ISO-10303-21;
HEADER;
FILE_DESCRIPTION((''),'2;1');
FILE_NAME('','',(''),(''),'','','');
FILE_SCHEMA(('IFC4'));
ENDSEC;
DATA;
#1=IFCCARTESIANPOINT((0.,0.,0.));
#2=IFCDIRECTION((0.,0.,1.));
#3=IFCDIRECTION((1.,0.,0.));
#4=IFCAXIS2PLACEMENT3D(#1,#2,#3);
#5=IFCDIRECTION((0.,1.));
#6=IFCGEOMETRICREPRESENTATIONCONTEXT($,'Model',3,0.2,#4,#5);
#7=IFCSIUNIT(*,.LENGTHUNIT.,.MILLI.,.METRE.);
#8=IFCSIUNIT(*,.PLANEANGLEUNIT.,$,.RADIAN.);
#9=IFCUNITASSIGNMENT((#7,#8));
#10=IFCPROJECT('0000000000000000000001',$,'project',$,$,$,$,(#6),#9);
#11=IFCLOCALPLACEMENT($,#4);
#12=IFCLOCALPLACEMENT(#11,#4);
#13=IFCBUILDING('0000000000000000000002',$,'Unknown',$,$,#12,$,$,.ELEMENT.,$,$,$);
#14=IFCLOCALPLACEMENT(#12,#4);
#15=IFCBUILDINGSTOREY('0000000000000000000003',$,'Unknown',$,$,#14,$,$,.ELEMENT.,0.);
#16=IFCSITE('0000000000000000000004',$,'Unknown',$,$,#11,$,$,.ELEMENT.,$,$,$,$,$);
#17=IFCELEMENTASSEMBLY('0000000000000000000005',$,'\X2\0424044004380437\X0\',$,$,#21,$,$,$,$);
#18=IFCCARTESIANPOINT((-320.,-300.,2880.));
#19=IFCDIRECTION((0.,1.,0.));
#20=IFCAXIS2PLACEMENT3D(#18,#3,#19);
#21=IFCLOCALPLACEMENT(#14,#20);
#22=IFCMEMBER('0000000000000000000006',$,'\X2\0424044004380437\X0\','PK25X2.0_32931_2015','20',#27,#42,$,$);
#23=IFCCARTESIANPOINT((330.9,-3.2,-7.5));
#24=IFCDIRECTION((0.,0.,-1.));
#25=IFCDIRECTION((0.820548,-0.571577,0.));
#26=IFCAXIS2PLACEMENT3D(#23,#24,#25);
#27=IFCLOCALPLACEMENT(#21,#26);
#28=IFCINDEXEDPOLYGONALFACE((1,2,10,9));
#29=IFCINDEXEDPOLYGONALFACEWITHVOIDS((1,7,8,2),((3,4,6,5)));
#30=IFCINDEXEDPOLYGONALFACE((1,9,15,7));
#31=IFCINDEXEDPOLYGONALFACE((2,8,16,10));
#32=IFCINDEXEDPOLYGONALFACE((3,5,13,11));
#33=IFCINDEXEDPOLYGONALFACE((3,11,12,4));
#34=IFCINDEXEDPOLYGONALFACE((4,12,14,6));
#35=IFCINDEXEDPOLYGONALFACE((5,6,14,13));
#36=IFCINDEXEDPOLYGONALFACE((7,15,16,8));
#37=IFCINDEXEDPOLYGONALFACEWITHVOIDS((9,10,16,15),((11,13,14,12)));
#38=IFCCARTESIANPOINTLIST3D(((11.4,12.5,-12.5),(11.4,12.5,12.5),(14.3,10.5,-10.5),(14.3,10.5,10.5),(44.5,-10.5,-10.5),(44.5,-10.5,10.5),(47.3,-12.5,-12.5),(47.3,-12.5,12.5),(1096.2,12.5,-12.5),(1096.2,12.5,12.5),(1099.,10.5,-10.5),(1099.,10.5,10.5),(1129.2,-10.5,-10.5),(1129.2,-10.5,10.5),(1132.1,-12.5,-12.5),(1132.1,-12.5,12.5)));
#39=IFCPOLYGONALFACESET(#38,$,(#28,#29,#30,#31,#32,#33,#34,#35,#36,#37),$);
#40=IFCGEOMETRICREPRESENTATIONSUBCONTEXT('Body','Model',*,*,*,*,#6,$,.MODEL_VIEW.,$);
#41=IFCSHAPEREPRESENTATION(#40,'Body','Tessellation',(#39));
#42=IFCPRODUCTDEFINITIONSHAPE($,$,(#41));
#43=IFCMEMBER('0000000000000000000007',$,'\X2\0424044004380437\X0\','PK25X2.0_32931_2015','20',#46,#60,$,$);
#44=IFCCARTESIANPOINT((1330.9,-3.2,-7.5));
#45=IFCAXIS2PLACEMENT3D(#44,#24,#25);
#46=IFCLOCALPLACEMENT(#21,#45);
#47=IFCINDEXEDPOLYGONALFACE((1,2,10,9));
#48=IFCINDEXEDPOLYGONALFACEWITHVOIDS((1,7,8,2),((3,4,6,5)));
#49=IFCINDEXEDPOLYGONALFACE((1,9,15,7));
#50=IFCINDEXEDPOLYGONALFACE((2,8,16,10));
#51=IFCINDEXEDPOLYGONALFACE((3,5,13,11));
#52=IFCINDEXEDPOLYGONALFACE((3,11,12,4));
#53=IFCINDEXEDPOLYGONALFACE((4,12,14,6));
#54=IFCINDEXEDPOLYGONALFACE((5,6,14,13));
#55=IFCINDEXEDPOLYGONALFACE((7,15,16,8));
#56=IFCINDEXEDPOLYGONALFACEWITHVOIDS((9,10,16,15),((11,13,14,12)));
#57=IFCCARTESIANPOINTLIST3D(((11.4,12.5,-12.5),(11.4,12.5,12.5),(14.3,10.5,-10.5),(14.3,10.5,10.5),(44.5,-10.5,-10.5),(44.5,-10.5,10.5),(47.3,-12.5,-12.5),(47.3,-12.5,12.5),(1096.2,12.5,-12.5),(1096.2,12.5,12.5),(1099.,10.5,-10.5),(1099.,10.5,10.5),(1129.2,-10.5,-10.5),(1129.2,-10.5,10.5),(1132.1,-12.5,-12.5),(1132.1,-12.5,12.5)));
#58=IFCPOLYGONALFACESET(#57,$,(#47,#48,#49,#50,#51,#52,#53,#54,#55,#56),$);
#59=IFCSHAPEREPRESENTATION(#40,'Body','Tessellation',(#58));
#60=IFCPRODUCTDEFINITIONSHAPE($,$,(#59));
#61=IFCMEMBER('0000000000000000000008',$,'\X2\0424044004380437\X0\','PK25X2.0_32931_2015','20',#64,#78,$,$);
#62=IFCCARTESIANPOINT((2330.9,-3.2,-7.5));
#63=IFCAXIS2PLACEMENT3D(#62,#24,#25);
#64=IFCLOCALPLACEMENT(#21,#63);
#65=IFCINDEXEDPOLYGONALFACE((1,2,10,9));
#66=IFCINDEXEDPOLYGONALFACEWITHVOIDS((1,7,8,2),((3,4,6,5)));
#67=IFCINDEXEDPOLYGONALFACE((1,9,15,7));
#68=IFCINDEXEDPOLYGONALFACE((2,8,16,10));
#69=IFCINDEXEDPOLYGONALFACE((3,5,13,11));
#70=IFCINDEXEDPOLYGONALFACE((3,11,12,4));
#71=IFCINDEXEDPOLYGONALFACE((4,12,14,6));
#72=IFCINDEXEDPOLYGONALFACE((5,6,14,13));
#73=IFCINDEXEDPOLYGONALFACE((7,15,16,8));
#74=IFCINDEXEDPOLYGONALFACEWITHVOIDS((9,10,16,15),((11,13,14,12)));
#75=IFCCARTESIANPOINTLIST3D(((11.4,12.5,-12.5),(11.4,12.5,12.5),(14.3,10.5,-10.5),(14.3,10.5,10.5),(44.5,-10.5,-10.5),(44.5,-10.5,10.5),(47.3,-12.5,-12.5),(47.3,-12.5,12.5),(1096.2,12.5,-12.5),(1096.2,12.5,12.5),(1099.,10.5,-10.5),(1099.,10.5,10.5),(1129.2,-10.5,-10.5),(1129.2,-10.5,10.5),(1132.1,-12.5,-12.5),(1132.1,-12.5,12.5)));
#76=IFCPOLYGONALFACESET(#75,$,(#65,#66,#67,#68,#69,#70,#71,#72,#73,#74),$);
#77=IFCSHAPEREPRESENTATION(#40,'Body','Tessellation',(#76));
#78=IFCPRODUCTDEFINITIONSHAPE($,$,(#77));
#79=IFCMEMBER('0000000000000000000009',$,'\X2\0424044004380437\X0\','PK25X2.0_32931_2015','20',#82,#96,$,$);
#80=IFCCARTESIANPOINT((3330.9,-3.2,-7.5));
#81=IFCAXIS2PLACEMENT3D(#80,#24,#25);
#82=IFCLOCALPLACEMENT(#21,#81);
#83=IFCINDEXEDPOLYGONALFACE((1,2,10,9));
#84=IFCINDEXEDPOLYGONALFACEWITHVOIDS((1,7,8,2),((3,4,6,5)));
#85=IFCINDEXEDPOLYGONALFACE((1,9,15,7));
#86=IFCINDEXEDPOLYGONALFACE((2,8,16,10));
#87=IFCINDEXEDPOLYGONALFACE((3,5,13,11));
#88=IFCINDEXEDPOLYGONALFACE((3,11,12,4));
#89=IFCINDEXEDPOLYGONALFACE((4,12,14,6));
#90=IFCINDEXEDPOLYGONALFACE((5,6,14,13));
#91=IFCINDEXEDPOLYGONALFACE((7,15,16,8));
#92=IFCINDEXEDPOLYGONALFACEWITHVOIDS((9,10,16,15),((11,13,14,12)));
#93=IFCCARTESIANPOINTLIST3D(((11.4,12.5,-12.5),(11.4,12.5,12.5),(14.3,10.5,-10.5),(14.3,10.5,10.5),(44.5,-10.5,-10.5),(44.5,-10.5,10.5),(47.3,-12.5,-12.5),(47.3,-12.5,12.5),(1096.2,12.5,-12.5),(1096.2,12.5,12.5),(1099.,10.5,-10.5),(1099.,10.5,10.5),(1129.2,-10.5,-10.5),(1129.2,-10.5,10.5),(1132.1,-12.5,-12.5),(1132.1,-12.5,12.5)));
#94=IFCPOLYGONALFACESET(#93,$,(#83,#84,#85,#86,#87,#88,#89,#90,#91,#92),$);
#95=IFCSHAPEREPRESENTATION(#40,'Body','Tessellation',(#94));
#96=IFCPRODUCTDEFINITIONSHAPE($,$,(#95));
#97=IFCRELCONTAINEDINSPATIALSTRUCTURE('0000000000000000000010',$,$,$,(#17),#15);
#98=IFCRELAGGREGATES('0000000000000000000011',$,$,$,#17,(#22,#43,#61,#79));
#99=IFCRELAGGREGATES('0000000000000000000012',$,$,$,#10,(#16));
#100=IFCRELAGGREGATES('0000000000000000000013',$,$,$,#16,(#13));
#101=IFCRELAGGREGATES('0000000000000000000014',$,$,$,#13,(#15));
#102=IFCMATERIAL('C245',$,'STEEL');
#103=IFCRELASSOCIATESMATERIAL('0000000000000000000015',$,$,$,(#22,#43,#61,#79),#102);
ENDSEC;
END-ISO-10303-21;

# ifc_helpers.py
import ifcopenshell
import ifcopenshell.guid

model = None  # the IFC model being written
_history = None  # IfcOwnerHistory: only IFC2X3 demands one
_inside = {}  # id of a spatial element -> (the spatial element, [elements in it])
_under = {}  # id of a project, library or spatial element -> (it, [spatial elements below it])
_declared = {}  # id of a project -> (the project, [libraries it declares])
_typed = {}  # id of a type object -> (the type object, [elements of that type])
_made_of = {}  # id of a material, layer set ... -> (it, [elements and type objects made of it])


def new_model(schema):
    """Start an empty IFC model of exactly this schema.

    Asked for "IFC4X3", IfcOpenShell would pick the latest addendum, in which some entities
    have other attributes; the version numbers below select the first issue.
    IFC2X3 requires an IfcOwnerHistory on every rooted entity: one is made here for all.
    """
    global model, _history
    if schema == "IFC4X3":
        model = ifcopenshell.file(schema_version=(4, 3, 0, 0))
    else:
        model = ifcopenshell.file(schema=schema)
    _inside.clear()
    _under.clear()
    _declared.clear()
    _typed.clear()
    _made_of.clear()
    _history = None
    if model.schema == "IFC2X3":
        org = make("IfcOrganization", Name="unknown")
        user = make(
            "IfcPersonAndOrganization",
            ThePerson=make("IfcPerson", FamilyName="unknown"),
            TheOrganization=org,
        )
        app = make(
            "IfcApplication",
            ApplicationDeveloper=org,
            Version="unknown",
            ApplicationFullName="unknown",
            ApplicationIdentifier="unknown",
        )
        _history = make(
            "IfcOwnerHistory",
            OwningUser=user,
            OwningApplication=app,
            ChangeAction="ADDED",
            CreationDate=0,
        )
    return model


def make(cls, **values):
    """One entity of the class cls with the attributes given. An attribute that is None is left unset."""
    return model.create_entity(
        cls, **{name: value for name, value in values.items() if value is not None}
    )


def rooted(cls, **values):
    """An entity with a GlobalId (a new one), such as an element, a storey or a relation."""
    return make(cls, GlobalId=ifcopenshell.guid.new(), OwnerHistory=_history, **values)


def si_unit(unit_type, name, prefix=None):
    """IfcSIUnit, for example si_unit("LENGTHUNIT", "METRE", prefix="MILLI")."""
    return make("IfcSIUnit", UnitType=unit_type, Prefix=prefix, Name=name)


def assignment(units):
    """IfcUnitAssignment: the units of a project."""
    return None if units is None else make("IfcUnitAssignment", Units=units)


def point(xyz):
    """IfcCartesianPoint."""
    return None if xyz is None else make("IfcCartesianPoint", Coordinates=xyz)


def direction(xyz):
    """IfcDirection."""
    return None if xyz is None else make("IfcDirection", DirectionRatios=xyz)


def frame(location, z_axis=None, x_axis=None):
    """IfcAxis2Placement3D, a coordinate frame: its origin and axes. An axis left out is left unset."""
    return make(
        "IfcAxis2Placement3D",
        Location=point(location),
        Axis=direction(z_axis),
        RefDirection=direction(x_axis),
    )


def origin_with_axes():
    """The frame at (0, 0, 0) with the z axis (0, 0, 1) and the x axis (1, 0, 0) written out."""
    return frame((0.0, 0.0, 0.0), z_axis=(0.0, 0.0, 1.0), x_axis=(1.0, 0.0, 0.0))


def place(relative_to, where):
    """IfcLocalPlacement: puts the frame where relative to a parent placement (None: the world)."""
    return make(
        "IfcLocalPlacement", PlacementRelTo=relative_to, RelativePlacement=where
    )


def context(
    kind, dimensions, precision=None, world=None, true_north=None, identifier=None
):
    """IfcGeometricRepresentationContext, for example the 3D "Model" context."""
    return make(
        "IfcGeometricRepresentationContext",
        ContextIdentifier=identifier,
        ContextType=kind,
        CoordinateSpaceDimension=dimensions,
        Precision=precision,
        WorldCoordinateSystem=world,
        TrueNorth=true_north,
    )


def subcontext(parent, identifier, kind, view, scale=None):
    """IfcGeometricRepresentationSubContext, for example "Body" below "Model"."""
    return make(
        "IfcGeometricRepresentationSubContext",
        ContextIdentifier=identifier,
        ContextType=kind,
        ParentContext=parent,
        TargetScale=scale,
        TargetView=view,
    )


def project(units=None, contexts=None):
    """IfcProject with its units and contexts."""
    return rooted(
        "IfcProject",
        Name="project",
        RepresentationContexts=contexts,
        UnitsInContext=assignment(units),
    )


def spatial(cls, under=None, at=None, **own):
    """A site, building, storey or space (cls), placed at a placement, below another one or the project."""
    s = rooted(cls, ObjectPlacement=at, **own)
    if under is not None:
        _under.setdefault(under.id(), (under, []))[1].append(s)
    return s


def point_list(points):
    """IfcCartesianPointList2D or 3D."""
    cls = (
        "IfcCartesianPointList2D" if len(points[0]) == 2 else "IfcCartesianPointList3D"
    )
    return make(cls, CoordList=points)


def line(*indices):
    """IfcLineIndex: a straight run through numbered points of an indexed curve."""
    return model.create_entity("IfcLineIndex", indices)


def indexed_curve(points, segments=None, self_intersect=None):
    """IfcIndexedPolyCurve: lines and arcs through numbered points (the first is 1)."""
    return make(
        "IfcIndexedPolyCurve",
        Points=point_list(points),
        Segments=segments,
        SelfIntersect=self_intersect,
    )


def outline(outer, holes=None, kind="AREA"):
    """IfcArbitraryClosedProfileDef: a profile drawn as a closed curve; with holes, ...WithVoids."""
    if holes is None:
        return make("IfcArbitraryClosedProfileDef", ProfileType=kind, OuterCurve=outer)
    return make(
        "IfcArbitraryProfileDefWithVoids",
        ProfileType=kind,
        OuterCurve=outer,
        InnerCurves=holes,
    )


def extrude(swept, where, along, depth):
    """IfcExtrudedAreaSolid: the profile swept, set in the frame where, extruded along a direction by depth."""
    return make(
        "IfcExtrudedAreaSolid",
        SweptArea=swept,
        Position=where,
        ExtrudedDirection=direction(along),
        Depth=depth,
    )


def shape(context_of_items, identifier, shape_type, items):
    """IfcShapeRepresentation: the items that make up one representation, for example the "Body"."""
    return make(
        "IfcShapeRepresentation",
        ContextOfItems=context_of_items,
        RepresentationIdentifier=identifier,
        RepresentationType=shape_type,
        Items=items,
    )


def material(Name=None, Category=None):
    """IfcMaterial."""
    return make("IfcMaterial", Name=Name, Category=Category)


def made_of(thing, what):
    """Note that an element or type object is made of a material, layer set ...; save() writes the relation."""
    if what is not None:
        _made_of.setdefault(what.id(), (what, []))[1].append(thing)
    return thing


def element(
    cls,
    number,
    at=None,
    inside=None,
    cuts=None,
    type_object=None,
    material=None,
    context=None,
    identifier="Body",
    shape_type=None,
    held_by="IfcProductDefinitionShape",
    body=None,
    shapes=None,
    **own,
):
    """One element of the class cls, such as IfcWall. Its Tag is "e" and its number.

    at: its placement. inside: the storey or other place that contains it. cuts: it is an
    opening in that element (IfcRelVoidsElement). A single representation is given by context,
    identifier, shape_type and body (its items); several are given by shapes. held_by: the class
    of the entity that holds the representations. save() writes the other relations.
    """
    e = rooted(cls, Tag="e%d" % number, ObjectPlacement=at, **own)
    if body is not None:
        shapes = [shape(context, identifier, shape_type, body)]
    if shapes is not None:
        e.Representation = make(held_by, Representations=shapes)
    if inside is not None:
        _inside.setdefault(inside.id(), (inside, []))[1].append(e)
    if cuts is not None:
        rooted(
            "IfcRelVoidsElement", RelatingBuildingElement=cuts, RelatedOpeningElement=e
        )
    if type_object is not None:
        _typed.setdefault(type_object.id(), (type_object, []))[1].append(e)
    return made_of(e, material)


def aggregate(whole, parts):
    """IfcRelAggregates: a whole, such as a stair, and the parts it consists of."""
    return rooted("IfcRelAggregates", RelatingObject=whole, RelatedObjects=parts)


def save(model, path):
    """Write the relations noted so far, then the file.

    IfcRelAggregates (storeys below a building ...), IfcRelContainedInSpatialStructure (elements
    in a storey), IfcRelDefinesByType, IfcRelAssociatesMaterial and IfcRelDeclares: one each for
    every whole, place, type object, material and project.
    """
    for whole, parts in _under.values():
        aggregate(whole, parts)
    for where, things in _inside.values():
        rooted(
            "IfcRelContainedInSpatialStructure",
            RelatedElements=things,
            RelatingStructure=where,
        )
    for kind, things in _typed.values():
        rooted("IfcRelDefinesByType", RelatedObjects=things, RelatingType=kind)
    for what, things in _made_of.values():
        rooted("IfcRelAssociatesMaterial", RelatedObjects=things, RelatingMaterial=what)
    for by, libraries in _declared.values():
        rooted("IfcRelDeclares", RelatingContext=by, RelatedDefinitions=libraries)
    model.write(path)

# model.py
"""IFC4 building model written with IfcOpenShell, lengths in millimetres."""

from ifc_helpers import new_model, si_unit, direction, frame, origin_with_axes, place, context, subcontext, project, spatial, line, indexed_curve, outline, extrude, material, element, aggregate, save


model = new_model("IFC4")

# Units and contexts
model_context = context("Model", 3, precision=0.2, world=origin_with_axes(), true_north=direction((0.0, 1.0)))
body_context = subcontext(model_context, "Body", "Model", "MODEL_VIEW")
ifc_project = project(units=[si_unit("LENGTHUNIT", "METRE", prefix="MILLI"), si_unit("PLANEANGLEUNIT", "RADIAN")], contexts=[model_context])

# Site, building, storey
site_placement = place(None, origin_with_axes())
site = spatial("IfcSite", under=ifc_project, at=site_placement, Name="Unknown", CompositionType="ELEMENT")
building_placement = place(site_placement, origin_with_axes())
building = spatial("IfcBuilding", under=site, at=building_placement, Name="Unknown", CompositionType="ELEMENT")
storey_placement = place(building_placement, origin_with_axes())
storey = spatial("IfcBuildingStorey", under=building, at=storey_placement, Name="Unknown", CompositionType="ELEMENT", Elevation=0.0)

# Shared definitions
ifc_material_1 = material(Name="C245", Category="STEEL")

# Element assembly, members, voiding features
assembly_1_placement = place(storey_placement, frame((-320.0, -300.0, 2880.0), z_axis=(1.0, 0.0, 0.0), x_axis=(0.0, 1.0, 0.0)))
assembly_1 = element("IfcElementAssembly", 1, at=assembly_1_placement, inside=storey, Name="Фриз")
member_1_placement = place(assembly_1_placement, frame((330.9, -3.2, -7.5), z_axis=(0.0, 0.0, -1.0), x_axis=(0.820548, -0.571577, 0.0)))
member_1 = element("IfcMember", 2, at=member_1_placement, material=ifc_material_1, Name="Фриз", Description="PK25X2.0_32931_2015", ObjectType="20", context=body_context, shape_type="SolidModel", body=[
    extrude(outline(indexed_curve([(-12.5, -12.5), (12.5, -12.5), (12.5, 12.5), (-12.5, 12.5)], segments=[line(1, 2, 3, 4, 1)]), holes=[indexed_curve([(-10.5, -10.5), (-10.5, 10.5), (10.5, 10.5), (10.5, -10.5)], segments=[line(1, 2, 3, 4, 1)])]), frame((0.0, 0.0, 0.0), z_axis=(-1.0, 0.0, 0.0), x_axis=(0.0, 0.0, 1.0)), (0.0, 0.0, -1.0), 1143.5),
])
voiding_feature_1_placement = place(member_1_placement, frame((-910.3, 630.2, -7.5), z_axis=(0.0, 0.0, -1.0), x_axis=(0.820548, -0.571577, 0.0)))
element("IfcVoidingFeature", 3, at=voiding_feature_1_placement, cuts=member_1, Name="CUT_BEAM", ObjectType="(?)", PredefinedType="HOLE", context=body_context, shape_type="SolidModel", body=[
    extrude(outline(indexed_curve([(-20.0, -20.0), (20.0, -20.0), (20.0, 20.0), (-20.0, 20.0)], segments=[line(1, 2, 3, 4, 1)])), frame((0.0, 0.0, 0.0), z_axis=(-1.0, 0.0, 0.0), x_axis=(0.0, 0.0, 1.0)), (0.0, 0.0, -1.0), 2205.1),
])
voiding_feature_2_placement = place(member_1_placement, frame((244.4, 630.2, -7.5), z_axis=(0.0, 0.0, -1.0), x_axis=(0.820548, -0.571577, 0.0)))
element("IfcVoidingFeature", 4, at=voiding_feature_2_placement, cuts=member_1, Name="CUT_BEAM", ObjectType="(?)", PredefinedType="HOLE", context=body_context, shape_type="SolidModel", body=[
    extrude(outline(indexed_curve([(-20.0, -20.0), (20.0, -20.0), (20.0, 20.0), (-20.0, 20.0)], segments=[line(1, 2, 3, 4, 1)])), frame((0.0, 0.0, 0.0), z_axis=(-1.0, 0.0, 0.0), x_axis=(0.0, 0.0, 1.0)), (0.0, 0.0, -1.0), 2205.1),
])
member_2_placement = place(assembly_1_placement, frame((1330.9, -3.2, -7.5), z_axis=(0.0, 0.0, -1.0), x_axis=(0.820548, -0.571577, 0.0)))
member_2 = element("IfcMember", 5, at=member_2_placement, material=ifc_material_1, Name="Фриз", Description="PK25X2.0_32931_2015", ObjectType="20", context=body_context, shape_type="SolidModel", body=[
    extrude(outline(indexed_curve([(-12.5, -12.5), (12.5, -12.5), (12.5, 12.5), (-12.5, 12.5)], segments=[line(1, 2, 3, 4, 1)]), holes=[indexed_curve([(-10.5, -10.5), (-10.5, 10.5), (10.5, 10.5), (10.5, -10.5)], segments=[line(1, 2, 3, 4, 1)])]), frame((0.0, 0.0, 0.0), z_axis=(-1.0, 0.0, 0.0), x_axis=(0.0, 0.0, 1.0)), (0.0, 0.0, -1.0), 1143.5),
])
voiding_feature_3_placement = place(member_2_placement, frame((-910.3, 630.2, -7.5), z_axis=(0.0, 0.0, -1.0), x_axis=(0.820548, -0.571577, 0.0)))
element("IfcVoidingFeature", 6, at=voiding_feature_3_placement, cuts=member_2, Name="CUT_BEAM", ObjectType="(?)", PredefinedType="HOLE", context=body_context, shape_type="SolidModel", body=[
    extrude(outline(indexed_curve([(-20.0, -20.0), (20.0, -20.0), (20.0, 20.0), (-20.0, 20.0)], segments=[line(1, 2, 3, 4, 1)])), frame((0.0, 0.0, 0.0), z_axis=(-1.0, 0.0, 0.0), x_axis=(0.0, 0.0, 1.0)), (0.0, 0.0, -1.0), 2205.1),
])
voiding_feature_4_placement = place(member_2_placement, frame((244.4, 630.2, -7.5), z_axis=(0.0, 0.0, -1.0), x_axis=(0.820548, -0.571577, 0.0)))
element("IfcVoidingFeature", 7, at=voiding_feature_4_placement, cuts=member_2, Name="CUT_BEAM", ObjectType="(?)", PredefinedType="HOLE", context=body_context, shape_type="SolidModel", body=[
    extrude(outline(indexed_curve([(-20.0, -20.0), (20.0, -20.0), (20.0, 20.0), (-20.0, 20.0)], segments=[line(1, 2, 3, 4, 1)])), frame((0.0, 0.0, 0.0), z_axis=(-1.0, 0.0, 0.0), x_axis=(0.0, 0.0, 1.0)), (0.0, 0.0, -1.0), 2205.1),
])
member_3_placement = place(assembly_1_placement, frame((2330.9, -3.2, -7.5), z_axis=(0.0, 0.0, -1.0), x_axis=(0.820548, -0.571577, 0.0)))
member_3 = element("IfcMember", 8, at=member_3_placement, material=ifc_material_1, Name="Фриз", Description="PK25X2.0_32931_2015", ObjectType="20", context=body_context, shape_type="SolidModel", body=[
    extrude(outline(indexed_curve([(-12.5, -12.5), (12.5, -12.5), (12.5, 12.5), (-12.5, 12.5)], segments=[line(1, 2, 3, 4, 1)]), holes=[indexed_curve([(-10.5, -10.5), (-10.5, 10.5), (10.5, 10.5), (10.5, -10.5)], segments=[line(1, 2, 3, 4, 1)])]), frame((0.0, 0.0, 0.0), z_axis=(-1.0, 0.0, 0.0), x_axis=(0.0, 0.0, 1.0)), (0.0, 0.0, -1.0), 1143.5),
])
voiding_feature_5_placement = place(member_3_placement, frame((-910.3, 630.2, -7.5), z_axis=(0.0, 0.0, -1.0), x_axis=(0.820548, -0.571577, 0.0)))
element("IfcVoidingFeature", 9, at=voiding_feature_5_placement, cuts=member_3, Name="CUT_BEAM", ObjectType="(?)", PredefinedType="HOLE", context=body_context, shape_type="SolidModel", body=[
    extrude(outline(indexed_curve([(-20.0, -20.0), (20.0, -20.0), (20.0, 20.0), (-20.0, 20.0)], segments=[line(1, 2, 3, 4, 1)])), frame((0.0, 0.0, 0.0), z_axis=(-1.0, 0.0, 0.0), x_axis=(0.0, 0.0, 1.0)), (0.0, 0.0, -1.0), 2205.1),
])
voiding_feature_6_placement = place(member_3_placement, frame((244.4, 630.2, -7.5), z_axis=(0.0, 0.0, -1.0), x_axis=(0.820548, -0.571577, 0.0)))
element("IfcVoidingFeature", 10, at=voiding_feature_6_placement, cuts=member_3, Name="CUT_BEAM", ObjectType="(?)", PredefinedType="HOLE", context=body_context, shape_type="SolidModel", body=[
    extrude(outline(indexed_curve([(-20.0, -20.0), (20.0, -20.0), (20.0, 20.0), (-20.0, 20.0)], segments=[line(1, 2, 3, 4, 1)])), frame((0.0, 0.0, 0.0), z_axis=(-1.0, 0.0, 0.0), x_axis=(0.0, 0.0, 1.0)), (0.0, 0.0, -1.0), 2205.1),
])
member_4_placement = place(assembly_1_placement, frame((3330.9, -3.2, -7.5), z_axis=(0.0, 0.0, -1.0), x_axis=(0.820548, -0.571577, 0.0)))
member_4 = element("IfcMember", 11, at=member_4_placement, material=ifc_material_1, Name="Фриз", Description="PK25X2.0_32931_2015", ObjectType="20", context=body_context, shape_type="SolidModel", body=[
    extrude(outline(indexed_curve([(-12.5, -12.5), (12.5, -12.5), (12.5, 12.5), (-12.5, 12.5)], segments=[line(1, 2, 3, 4, 1)]), holes=[indexed_curve([(-10.5, -10.5), (-10.5, 10.5), (10.5, 10.5), (10.5, -10.5)], segments=[line(1, 2, 3, 4, 1)])]), frame((0.0, 0.0, 0.0), z_axis=(-1.0, 0.0, 0.0), x_axis=(0.0, 0.0, 1.0)), (0.0, 0.0, -1.0), 1143.5),
])
voiding_feature_7_placement = place(member_4_placement, frame((-910.3, 630.2, -7.5), z_axis=(0.0, 0.0, -1.0), x_axis=(0.820548, -0.571577, 0.0)))
element("IfcVoidingFeature", 12, at=voiding_feature_7_placement, cuts=member_4, Name="CUT_BEAM", ObjectType="(?)", PredefinedType="HOLE", context=body_context, shape_type="SolidModel", body=[
    extrude(outline(indexed_curve([(-20.0, -20.0), (20.0, -20.0), (20.0, 20.0), (-20.0, 20.0)], segments=[line(1, 2, 3, 4, 1)])), frame((0.0, 0.0, 0.0), z_axis=(-1.0, 0.0, 0.0), x_axis=(0.0, 0.0, 1.0)), (0.0, 0.0, -1.0), 2205.1),
])
voiding_feature_8_placement = place(member_4_placement, frame((244.4, 630.2, -7.5), z_axis=(0.0, 0.0, -1.0), x_axis=(0.820548, -0.571577, 0.0)))
element("IfcVoidingFeature", 13, at=voiding_feature_8_placement, cuts=member_4, Name="CUT_BEAM", ObjectType="(?)", PredefinedType="HOLE", context=body_context, shape_type="SolidModel", body=[
    extrude(outline(indexed_curve([(-20.0, -20.0), (20.0, -20.0), (20.0, 20.0), (-20.0, 20.0)], segments=[line(1, 2, 3, 4, 1)])), frame((0.0, 0.0, 0.0), z_axis=(-1.0, 0.0, 0.0), x_axis=(0.0, 0.0, 1.0)), (0.0, 0.0, -1.0), 2205.1),
])
aggregate(assembly_1, [member_1, member_2, member_3, member_4])

save(model, "model.ifc")
